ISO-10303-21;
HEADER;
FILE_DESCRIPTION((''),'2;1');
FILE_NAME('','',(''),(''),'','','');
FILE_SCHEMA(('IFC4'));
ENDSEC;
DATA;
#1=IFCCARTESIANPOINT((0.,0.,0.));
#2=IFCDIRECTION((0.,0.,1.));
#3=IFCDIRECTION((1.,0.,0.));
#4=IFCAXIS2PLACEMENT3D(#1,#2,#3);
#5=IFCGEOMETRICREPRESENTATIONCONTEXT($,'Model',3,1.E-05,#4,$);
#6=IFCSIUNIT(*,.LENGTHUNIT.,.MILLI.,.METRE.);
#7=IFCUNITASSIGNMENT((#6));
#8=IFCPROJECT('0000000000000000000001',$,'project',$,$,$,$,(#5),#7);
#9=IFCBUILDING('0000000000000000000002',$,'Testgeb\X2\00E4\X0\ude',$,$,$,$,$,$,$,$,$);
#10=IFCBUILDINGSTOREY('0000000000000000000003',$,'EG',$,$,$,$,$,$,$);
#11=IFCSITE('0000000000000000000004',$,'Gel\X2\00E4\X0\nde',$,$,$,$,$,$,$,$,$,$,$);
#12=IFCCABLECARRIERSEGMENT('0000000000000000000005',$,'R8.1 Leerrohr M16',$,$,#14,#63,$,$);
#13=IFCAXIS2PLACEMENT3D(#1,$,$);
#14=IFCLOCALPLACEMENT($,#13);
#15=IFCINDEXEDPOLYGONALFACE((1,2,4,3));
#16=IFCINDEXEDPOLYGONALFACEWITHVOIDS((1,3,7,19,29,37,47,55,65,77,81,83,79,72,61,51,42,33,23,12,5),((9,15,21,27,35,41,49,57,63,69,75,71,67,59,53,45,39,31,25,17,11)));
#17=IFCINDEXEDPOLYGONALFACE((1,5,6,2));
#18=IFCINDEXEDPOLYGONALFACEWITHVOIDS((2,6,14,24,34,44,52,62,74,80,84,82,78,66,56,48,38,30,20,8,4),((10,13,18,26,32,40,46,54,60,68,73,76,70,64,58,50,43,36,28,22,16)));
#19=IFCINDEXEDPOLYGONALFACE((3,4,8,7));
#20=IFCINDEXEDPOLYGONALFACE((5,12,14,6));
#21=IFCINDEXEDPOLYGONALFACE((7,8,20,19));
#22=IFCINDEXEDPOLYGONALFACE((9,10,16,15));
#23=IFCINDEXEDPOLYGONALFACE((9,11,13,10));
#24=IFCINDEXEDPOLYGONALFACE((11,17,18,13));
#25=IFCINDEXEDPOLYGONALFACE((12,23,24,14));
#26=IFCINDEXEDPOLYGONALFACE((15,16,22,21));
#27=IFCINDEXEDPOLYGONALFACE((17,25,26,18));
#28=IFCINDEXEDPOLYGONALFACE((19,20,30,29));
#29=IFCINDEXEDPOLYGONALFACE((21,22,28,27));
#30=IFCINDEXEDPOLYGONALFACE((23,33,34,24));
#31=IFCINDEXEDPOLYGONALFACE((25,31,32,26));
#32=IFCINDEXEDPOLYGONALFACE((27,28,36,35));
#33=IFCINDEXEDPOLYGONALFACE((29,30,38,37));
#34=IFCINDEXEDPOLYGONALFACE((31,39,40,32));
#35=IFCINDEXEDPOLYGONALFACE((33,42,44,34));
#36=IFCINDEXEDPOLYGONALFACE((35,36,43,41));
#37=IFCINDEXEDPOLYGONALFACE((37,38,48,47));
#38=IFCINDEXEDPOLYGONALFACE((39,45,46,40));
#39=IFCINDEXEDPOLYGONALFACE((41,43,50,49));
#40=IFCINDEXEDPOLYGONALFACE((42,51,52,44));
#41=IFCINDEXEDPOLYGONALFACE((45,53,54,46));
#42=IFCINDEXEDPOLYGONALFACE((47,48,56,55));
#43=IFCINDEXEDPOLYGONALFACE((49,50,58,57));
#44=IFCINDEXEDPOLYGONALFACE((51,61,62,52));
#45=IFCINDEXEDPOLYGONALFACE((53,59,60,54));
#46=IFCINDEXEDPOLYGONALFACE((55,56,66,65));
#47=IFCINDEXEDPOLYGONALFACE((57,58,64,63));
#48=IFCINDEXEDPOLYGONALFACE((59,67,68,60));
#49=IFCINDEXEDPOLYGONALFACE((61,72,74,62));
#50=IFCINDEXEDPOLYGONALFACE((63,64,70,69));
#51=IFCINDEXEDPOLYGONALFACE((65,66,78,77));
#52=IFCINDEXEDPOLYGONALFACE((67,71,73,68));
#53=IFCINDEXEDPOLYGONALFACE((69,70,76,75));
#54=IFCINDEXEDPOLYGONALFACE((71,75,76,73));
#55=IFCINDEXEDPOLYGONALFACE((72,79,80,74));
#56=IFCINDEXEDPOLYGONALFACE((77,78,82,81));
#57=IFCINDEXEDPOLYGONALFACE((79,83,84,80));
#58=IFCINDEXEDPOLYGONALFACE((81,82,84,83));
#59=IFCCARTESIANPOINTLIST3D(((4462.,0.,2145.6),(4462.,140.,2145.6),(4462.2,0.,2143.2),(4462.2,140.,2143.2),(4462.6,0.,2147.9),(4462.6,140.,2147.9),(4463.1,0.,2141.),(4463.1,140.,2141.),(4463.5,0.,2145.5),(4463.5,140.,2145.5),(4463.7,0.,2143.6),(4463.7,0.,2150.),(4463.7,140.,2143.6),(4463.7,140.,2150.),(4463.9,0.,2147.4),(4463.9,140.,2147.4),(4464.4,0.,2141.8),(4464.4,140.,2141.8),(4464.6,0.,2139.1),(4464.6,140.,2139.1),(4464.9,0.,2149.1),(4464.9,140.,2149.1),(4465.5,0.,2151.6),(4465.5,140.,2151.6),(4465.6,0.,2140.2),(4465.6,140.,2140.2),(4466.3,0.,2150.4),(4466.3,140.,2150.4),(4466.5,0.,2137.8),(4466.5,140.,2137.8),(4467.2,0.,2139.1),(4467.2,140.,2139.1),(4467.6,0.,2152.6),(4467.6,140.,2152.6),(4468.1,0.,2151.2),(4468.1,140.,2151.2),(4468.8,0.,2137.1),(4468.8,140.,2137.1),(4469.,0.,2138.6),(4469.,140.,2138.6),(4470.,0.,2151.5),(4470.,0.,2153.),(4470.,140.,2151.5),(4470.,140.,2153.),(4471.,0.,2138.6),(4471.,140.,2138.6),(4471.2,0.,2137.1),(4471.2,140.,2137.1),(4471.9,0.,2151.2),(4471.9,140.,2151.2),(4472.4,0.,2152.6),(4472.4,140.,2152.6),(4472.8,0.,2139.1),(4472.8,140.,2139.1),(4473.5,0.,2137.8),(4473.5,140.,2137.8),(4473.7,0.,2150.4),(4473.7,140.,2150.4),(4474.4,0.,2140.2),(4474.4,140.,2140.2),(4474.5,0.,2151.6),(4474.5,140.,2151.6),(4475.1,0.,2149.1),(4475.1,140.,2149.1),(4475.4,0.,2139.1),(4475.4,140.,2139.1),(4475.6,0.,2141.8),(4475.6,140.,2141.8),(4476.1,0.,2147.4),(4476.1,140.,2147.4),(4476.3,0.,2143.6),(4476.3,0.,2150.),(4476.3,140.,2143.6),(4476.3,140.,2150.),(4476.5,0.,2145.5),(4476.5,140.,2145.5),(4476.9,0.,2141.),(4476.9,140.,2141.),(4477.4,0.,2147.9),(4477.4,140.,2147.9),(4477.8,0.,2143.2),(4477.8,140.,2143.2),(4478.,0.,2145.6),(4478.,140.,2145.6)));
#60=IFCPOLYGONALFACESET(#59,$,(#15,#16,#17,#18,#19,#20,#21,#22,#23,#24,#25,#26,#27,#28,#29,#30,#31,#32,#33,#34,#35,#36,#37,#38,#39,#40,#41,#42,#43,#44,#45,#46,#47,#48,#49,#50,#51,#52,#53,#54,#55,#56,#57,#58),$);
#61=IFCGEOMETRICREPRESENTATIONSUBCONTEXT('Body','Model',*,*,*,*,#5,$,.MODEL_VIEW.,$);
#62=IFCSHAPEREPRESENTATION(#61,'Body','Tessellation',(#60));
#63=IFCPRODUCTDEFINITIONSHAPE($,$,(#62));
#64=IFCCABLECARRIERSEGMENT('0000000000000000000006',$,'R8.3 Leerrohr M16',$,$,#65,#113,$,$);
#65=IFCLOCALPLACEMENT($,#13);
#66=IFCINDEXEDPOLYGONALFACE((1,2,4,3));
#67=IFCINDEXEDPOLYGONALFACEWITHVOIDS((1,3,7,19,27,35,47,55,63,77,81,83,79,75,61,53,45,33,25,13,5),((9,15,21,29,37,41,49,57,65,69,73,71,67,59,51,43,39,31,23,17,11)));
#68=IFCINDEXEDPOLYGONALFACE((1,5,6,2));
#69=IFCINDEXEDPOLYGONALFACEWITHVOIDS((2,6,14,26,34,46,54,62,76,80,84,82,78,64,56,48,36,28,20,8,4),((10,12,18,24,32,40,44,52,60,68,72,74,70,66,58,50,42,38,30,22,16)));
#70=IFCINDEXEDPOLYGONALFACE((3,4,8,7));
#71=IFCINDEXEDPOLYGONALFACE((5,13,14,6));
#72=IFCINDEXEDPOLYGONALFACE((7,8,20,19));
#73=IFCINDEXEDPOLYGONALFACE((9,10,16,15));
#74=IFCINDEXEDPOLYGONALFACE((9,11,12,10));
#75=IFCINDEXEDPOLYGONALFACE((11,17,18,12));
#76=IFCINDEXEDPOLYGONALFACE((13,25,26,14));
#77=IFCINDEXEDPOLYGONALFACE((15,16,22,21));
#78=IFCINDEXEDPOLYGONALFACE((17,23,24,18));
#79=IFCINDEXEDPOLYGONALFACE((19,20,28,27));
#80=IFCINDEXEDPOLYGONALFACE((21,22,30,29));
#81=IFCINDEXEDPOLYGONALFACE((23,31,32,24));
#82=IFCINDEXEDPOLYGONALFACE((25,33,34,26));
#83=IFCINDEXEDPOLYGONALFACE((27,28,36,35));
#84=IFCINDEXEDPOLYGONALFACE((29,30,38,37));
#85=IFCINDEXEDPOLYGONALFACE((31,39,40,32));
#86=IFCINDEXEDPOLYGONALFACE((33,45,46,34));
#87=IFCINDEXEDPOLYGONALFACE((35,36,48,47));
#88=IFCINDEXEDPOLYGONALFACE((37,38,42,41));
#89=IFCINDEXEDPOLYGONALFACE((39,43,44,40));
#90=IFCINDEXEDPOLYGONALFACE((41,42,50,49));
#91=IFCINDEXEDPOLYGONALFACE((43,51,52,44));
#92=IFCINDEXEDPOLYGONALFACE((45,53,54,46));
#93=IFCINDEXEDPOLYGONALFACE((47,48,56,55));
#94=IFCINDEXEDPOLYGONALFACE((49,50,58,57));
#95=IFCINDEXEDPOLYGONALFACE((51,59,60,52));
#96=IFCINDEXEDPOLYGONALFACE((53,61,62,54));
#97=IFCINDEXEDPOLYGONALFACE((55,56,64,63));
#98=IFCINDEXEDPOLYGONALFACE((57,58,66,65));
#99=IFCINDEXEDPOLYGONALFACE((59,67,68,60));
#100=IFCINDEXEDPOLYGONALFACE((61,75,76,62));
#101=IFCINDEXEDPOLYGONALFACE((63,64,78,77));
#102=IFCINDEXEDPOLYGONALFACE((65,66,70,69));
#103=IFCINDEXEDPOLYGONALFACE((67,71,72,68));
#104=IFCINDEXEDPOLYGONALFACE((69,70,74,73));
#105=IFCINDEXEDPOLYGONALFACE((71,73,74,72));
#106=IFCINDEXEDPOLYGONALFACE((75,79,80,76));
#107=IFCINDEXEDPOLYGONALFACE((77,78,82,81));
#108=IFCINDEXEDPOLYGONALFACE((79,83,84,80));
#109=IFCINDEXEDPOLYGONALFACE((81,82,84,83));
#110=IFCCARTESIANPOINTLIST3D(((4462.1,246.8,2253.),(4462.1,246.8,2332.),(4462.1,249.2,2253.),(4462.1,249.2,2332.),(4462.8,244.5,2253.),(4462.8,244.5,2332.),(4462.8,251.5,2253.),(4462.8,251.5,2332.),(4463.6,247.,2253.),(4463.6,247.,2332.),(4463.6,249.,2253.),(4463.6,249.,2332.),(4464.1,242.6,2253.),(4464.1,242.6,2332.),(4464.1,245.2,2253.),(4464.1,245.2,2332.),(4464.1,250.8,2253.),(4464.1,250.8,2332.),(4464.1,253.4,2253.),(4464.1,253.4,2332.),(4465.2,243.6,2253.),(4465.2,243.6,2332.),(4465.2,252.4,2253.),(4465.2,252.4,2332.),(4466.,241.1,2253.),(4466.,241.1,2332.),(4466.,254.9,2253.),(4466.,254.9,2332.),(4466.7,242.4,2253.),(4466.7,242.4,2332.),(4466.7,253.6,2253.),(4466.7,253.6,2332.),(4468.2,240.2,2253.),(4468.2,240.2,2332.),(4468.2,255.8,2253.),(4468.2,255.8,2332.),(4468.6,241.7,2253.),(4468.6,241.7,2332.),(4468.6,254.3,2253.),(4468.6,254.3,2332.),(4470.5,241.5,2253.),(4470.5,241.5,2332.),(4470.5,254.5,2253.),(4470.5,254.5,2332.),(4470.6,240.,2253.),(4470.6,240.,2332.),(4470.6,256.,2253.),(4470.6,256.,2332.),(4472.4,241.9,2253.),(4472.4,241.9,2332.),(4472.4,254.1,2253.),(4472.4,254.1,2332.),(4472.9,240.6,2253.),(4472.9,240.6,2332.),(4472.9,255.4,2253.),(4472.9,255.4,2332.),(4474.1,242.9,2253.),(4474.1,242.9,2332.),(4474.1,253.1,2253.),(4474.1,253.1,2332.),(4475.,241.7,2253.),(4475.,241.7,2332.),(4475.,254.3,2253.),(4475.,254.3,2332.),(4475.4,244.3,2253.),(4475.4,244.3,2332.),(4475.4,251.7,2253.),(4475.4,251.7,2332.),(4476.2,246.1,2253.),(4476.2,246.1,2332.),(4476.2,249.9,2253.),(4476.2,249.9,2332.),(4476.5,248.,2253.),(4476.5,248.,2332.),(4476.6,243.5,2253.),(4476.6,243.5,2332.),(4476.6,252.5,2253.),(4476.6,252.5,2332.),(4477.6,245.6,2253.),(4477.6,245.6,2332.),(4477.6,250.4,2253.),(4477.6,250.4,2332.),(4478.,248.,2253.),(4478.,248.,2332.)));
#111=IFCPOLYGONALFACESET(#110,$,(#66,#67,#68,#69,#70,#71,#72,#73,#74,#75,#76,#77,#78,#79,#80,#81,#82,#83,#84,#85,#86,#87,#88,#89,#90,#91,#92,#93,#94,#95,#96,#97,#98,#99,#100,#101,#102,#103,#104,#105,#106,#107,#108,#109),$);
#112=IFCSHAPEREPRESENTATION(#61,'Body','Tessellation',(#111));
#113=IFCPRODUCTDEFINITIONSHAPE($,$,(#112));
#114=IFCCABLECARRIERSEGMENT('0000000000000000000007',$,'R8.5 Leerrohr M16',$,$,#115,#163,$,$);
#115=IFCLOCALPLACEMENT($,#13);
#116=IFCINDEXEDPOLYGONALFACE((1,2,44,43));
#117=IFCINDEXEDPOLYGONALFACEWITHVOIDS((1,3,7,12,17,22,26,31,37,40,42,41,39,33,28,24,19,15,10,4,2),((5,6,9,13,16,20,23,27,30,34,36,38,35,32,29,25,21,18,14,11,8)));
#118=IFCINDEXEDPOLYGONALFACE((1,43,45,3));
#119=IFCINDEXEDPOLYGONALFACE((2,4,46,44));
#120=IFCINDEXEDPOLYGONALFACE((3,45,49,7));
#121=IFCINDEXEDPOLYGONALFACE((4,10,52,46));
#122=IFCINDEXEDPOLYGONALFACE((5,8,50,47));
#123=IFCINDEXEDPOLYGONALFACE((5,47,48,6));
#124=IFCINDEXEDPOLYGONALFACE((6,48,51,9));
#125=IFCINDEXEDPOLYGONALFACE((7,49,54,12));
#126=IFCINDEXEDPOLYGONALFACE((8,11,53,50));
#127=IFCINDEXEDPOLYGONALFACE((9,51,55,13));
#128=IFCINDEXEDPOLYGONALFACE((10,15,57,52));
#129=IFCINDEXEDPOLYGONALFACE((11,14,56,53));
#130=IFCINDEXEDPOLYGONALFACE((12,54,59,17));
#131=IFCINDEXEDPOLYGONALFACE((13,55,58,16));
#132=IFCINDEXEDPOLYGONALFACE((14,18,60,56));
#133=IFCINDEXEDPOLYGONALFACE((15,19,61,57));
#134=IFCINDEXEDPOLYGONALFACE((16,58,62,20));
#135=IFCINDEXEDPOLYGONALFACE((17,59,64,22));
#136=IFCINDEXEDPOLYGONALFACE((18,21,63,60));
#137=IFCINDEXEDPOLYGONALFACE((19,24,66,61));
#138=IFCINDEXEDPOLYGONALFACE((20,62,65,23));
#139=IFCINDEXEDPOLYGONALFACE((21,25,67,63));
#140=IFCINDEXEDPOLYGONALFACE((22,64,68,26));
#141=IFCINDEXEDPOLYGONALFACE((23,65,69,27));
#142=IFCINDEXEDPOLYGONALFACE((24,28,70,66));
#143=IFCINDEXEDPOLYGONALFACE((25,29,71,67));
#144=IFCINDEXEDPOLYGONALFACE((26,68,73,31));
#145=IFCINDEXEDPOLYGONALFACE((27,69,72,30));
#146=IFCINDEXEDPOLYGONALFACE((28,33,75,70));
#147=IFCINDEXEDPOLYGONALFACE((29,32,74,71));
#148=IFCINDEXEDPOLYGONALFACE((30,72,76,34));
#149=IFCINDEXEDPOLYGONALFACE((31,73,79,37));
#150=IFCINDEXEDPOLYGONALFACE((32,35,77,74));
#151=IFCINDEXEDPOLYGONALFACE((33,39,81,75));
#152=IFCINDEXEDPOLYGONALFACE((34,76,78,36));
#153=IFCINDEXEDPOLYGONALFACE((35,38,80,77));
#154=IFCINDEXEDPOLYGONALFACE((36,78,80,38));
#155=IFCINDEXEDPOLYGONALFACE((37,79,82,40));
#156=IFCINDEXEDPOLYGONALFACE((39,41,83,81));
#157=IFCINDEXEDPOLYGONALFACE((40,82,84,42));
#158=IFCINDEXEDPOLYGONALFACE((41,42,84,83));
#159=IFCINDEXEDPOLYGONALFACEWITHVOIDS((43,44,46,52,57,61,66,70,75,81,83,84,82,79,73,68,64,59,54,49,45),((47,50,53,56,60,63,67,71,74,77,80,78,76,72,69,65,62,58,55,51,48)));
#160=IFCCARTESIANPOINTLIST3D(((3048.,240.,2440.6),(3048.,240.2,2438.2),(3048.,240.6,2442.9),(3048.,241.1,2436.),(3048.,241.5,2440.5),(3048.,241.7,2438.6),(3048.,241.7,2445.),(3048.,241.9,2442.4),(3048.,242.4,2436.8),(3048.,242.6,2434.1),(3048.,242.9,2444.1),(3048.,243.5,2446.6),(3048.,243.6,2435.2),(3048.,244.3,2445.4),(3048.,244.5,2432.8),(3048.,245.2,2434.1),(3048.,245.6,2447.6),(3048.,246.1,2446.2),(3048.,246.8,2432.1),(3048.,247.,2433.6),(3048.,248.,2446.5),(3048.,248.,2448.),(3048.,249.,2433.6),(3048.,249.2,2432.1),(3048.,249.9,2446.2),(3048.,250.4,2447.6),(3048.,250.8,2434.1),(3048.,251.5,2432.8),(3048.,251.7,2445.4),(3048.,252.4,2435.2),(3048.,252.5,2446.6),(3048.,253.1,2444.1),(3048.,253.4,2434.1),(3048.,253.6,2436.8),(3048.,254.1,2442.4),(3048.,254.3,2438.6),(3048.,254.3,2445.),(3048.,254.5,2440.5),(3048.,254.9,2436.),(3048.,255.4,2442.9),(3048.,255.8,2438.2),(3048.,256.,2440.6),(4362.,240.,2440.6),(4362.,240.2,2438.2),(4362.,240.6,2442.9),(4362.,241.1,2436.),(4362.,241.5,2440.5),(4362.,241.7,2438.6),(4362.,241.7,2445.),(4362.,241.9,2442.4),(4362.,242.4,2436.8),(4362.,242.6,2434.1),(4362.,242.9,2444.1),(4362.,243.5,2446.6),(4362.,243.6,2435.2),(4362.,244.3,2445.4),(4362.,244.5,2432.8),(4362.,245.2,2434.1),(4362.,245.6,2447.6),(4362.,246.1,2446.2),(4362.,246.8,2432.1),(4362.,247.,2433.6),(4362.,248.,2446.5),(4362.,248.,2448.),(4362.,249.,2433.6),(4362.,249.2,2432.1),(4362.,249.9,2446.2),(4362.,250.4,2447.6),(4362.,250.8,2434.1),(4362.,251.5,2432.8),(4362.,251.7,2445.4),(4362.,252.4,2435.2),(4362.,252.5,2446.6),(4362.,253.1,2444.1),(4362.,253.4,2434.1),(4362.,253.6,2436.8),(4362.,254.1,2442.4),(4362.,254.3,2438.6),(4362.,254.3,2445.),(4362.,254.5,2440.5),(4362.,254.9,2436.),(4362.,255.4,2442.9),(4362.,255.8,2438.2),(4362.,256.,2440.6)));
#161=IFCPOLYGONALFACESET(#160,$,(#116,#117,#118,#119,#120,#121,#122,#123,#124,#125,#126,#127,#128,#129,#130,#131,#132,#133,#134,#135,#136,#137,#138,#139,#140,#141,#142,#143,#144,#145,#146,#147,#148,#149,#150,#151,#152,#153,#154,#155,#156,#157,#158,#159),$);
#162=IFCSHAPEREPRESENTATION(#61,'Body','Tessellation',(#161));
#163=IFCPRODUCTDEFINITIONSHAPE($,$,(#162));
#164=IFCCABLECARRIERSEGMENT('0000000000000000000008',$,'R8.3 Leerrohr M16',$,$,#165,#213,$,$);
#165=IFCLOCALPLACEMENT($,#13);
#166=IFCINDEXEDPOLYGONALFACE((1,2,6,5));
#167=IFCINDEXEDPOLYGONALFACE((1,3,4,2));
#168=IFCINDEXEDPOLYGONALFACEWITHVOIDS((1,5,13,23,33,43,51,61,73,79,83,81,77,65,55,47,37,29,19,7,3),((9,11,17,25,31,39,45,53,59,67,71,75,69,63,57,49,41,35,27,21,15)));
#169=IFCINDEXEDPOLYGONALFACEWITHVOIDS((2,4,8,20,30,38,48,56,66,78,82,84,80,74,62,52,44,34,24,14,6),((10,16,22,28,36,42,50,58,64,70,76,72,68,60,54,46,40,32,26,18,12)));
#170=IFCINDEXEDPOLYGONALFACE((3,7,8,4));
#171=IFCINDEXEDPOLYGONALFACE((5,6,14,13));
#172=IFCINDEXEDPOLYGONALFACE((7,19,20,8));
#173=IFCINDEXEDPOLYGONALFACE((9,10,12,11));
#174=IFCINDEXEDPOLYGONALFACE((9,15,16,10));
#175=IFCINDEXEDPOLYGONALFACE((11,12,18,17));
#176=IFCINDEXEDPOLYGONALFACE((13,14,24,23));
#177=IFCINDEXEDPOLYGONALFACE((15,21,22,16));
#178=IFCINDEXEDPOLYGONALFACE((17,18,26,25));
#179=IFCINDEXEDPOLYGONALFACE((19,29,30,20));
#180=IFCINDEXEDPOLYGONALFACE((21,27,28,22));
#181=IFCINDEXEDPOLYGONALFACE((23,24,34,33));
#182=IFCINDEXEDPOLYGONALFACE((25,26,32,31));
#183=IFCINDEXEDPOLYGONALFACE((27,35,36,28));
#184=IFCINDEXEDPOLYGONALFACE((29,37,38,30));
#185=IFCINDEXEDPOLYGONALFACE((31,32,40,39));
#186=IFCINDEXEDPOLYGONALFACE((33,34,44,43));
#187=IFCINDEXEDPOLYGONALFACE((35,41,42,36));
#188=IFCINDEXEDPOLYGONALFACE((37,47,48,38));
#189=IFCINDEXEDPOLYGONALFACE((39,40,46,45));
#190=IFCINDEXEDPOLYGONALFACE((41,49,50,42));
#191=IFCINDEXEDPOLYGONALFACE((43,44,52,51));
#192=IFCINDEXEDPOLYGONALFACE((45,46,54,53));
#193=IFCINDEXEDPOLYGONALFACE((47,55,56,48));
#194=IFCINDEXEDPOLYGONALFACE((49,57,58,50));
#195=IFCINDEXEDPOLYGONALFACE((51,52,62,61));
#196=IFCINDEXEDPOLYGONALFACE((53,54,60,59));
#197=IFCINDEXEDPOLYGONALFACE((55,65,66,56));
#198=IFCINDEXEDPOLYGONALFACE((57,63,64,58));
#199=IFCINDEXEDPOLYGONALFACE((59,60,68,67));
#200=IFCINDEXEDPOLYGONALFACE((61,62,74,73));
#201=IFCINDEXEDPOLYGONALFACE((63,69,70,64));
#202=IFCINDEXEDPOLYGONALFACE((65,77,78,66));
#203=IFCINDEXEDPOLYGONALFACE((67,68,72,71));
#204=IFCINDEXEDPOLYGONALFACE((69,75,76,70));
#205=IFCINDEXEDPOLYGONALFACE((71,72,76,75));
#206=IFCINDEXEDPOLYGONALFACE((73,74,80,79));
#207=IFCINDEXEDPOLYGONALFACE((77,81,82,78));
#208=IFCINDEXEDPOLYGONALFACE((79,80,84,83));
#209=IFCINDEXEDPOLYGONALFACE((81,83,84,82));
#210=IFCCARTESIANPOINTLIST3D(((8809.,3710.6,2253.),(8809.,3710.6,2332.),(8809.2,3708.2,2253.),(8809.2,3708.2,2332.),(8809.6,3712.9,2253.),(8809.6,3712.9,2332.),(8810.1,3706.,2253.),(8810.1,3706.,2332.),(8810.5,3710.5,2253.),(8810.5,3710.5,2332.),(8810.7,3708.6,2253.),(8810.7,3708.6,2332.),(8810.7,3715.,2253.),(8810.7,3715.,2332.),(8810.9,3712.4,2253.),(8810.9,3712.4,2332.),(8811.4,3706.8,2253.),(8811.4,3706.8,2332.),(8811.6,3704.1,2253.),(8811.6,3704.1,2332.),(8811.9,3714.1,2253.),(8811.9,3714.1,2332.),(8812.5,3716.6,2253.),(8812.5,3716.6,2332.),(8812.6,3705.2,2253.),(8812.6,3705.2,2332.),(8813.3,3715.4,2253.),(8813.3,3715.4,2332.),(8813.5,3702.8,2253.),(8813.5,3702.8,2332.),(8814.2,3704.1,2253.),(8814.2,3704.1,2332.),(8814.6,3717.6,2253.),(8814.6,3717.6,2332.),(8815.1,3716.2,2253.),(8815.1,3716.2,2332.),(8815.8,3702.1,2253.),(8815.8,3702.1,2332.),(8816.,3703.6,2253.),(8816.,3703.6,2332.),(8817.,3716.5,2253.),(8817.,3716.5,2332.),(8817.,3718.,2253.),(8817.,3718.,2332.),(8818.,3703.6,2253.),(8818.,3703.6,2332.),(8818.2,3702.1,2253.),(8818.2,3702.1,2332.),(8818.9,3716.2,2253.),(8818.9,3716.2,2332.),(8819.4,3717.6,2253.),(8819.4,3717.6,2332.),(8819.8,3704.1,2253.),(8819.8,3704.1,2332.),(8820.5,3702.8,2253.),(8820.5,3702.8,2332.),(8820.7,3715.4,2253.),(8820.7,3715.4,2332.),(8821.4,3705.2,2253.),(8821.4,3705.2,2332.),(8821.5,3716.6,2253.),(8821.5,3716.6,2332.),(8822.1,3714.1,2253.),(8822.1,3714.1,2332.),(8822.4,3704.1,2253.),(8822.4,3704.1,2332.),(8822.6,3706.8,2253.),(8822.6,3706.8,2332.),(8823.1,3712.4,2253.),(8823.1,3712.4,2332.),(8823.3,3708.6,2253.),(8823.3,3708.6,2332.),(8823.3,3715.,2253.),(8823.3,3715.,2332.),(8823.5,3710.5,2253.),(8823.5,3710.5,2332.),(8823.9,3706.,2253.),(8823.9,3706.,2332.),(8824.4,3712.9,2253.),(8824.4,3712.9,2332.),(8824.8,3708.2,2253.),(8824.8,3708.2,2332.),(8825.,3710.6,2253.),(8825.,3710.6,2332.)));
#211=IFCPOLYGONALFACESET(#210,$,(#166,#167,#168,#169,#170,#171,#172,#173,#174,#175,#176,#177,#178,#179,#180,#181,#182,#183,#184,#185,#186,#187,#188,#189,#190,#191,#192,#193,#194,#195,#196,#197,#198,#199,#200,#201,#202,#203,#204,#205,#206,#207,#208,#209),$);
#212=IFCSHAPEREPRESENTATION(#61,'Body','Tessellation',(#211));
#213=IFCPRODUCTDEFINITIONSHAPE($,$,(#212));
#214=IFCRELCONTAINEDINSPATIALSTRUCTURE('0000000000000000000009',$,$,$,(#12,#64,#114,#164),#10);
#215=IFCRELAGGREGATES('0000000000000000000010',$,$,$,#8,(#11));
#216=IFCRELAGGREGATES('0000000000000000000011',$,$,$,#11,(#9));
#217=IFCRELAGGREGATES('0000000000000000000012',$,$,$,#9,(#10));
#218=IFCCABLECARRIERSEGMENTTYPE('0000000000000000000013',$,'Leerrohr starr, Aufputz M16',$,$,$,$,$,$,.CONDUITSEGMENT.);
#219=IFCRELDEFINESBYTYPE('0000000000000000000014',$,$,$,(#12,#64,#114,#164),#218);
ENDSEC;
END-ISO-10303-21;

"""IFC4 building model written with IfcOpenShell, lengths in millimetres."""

from ifc_helpers import new_model, si_unit, frame, origin_with_axes, place, context, subcontext, project, spatial, hollow_circle, extrude, type_object, element, save


model = new_model("IFC4")

# Units and contexts
model_context = context("Model", 3, precision=1e-05, world=origin_with_axes())
body_context = subcontext(model_context, "Body", "Model", "MODEL_VIEW")
ifc_project = project(units=[si_unit("LENGTHUNIT", "METRE", prefix="MILLI")], contexts=[model_context])

# Site, building, storey
site = spatial("IfcSite", under=ifc_project, Name="Gelände")
building = spatial("IfcBuilding", under=site, Name="Testgebäude")
storey = spatial("IfcBuildingStorey", under=building, Name="EG")

# Cable carrier segments
cable_carrier_segment_type_1 = type_object("IfcCableCarrierSegmentType", Name="Leerrohr starr, Aufputz M16", PredefinedType="CONDUITSEGMENT")
cable_carrier_segment_1_placement = place(None, frame((4470.0, 0.0, 2145.0), z_axis=(0.0, 1.0, 0.0), x_axis=(0.0, 0.0, 1.0)))
element("IfcCableCarrierSegment", 1, at=cable_carrier_segment_1_placement, inside=storey, type_object=cable_carrier_segment_type_1, Name="R8.1 Leerrohr M16", context=body_context, shape_type="SweptSolid", body=[
    extrude(hollow_circle(Radius=8.0, WallThickness=1.5), None, (0.0, 0.0, 1.0), 140.0),
])
cable_carrier_segment_2_placement = place(None, frame((4470.0, 248.0, 2253.0), z_axis=(0.0, 0.0, 1.0), x_axis=(1.0, 0.0, 0.0)))
element("IfcCableCarrierSegment", 2, at=cable_carrier_segment_2_placement, inside=storey, type_object=cable_carrier_segment_type_1, Name="R8.3 Leerrohr M16", context=body_context, shape_type="SweptSolid", body=[
    extrude(hollow_circle(Radius=8.0, WallThickness=1.5), None, (0.0, 0.0, 1.0), 79.0),
])
cable_carrier_segment_3_placement = place(None, frame((4362.0, 248.0, 2440.0), z_axis=(-1.0, 0.0, 0.0), x_axis=(0.0, 0.0, 1.0)))
element("IfcCableCarrierSegment", 3, at=cable_carrier_segment_3_placement, inside=storey, type_object=cable_carrier_segment_type_1, Name="R8.5 Leerrohr M16", context=body_context, shape_type="SweptSolid", body=[
    extrude(hollow_circle(Radius=8.0, WallThickness=1.5), None, (0.0, 0.0, 1.0), 1314.0),
])
cable_carrier_segment_4_placement = place(None, frame((8817.0, 3710.0, 2253.0), z_axis=(0.0, 0.0, 1.0), x_axis=(0.0, 1.0, 0.0)))
element("IfcCableCarrierSegment", 4, at=cable_carrier_segment_4_placement, inside=storey, type_object=cable_carrier_segment_type_1, Name="R8.3 Leerrohr M16", context=body_context, shape_type="SweptSolid", body=[
    extrude(hollow_circle(Radius=8.0, WallThickness=1.5), None, (0.0, 0.0, 1.0), 79.0),
])

save(model, "model.ifc")
